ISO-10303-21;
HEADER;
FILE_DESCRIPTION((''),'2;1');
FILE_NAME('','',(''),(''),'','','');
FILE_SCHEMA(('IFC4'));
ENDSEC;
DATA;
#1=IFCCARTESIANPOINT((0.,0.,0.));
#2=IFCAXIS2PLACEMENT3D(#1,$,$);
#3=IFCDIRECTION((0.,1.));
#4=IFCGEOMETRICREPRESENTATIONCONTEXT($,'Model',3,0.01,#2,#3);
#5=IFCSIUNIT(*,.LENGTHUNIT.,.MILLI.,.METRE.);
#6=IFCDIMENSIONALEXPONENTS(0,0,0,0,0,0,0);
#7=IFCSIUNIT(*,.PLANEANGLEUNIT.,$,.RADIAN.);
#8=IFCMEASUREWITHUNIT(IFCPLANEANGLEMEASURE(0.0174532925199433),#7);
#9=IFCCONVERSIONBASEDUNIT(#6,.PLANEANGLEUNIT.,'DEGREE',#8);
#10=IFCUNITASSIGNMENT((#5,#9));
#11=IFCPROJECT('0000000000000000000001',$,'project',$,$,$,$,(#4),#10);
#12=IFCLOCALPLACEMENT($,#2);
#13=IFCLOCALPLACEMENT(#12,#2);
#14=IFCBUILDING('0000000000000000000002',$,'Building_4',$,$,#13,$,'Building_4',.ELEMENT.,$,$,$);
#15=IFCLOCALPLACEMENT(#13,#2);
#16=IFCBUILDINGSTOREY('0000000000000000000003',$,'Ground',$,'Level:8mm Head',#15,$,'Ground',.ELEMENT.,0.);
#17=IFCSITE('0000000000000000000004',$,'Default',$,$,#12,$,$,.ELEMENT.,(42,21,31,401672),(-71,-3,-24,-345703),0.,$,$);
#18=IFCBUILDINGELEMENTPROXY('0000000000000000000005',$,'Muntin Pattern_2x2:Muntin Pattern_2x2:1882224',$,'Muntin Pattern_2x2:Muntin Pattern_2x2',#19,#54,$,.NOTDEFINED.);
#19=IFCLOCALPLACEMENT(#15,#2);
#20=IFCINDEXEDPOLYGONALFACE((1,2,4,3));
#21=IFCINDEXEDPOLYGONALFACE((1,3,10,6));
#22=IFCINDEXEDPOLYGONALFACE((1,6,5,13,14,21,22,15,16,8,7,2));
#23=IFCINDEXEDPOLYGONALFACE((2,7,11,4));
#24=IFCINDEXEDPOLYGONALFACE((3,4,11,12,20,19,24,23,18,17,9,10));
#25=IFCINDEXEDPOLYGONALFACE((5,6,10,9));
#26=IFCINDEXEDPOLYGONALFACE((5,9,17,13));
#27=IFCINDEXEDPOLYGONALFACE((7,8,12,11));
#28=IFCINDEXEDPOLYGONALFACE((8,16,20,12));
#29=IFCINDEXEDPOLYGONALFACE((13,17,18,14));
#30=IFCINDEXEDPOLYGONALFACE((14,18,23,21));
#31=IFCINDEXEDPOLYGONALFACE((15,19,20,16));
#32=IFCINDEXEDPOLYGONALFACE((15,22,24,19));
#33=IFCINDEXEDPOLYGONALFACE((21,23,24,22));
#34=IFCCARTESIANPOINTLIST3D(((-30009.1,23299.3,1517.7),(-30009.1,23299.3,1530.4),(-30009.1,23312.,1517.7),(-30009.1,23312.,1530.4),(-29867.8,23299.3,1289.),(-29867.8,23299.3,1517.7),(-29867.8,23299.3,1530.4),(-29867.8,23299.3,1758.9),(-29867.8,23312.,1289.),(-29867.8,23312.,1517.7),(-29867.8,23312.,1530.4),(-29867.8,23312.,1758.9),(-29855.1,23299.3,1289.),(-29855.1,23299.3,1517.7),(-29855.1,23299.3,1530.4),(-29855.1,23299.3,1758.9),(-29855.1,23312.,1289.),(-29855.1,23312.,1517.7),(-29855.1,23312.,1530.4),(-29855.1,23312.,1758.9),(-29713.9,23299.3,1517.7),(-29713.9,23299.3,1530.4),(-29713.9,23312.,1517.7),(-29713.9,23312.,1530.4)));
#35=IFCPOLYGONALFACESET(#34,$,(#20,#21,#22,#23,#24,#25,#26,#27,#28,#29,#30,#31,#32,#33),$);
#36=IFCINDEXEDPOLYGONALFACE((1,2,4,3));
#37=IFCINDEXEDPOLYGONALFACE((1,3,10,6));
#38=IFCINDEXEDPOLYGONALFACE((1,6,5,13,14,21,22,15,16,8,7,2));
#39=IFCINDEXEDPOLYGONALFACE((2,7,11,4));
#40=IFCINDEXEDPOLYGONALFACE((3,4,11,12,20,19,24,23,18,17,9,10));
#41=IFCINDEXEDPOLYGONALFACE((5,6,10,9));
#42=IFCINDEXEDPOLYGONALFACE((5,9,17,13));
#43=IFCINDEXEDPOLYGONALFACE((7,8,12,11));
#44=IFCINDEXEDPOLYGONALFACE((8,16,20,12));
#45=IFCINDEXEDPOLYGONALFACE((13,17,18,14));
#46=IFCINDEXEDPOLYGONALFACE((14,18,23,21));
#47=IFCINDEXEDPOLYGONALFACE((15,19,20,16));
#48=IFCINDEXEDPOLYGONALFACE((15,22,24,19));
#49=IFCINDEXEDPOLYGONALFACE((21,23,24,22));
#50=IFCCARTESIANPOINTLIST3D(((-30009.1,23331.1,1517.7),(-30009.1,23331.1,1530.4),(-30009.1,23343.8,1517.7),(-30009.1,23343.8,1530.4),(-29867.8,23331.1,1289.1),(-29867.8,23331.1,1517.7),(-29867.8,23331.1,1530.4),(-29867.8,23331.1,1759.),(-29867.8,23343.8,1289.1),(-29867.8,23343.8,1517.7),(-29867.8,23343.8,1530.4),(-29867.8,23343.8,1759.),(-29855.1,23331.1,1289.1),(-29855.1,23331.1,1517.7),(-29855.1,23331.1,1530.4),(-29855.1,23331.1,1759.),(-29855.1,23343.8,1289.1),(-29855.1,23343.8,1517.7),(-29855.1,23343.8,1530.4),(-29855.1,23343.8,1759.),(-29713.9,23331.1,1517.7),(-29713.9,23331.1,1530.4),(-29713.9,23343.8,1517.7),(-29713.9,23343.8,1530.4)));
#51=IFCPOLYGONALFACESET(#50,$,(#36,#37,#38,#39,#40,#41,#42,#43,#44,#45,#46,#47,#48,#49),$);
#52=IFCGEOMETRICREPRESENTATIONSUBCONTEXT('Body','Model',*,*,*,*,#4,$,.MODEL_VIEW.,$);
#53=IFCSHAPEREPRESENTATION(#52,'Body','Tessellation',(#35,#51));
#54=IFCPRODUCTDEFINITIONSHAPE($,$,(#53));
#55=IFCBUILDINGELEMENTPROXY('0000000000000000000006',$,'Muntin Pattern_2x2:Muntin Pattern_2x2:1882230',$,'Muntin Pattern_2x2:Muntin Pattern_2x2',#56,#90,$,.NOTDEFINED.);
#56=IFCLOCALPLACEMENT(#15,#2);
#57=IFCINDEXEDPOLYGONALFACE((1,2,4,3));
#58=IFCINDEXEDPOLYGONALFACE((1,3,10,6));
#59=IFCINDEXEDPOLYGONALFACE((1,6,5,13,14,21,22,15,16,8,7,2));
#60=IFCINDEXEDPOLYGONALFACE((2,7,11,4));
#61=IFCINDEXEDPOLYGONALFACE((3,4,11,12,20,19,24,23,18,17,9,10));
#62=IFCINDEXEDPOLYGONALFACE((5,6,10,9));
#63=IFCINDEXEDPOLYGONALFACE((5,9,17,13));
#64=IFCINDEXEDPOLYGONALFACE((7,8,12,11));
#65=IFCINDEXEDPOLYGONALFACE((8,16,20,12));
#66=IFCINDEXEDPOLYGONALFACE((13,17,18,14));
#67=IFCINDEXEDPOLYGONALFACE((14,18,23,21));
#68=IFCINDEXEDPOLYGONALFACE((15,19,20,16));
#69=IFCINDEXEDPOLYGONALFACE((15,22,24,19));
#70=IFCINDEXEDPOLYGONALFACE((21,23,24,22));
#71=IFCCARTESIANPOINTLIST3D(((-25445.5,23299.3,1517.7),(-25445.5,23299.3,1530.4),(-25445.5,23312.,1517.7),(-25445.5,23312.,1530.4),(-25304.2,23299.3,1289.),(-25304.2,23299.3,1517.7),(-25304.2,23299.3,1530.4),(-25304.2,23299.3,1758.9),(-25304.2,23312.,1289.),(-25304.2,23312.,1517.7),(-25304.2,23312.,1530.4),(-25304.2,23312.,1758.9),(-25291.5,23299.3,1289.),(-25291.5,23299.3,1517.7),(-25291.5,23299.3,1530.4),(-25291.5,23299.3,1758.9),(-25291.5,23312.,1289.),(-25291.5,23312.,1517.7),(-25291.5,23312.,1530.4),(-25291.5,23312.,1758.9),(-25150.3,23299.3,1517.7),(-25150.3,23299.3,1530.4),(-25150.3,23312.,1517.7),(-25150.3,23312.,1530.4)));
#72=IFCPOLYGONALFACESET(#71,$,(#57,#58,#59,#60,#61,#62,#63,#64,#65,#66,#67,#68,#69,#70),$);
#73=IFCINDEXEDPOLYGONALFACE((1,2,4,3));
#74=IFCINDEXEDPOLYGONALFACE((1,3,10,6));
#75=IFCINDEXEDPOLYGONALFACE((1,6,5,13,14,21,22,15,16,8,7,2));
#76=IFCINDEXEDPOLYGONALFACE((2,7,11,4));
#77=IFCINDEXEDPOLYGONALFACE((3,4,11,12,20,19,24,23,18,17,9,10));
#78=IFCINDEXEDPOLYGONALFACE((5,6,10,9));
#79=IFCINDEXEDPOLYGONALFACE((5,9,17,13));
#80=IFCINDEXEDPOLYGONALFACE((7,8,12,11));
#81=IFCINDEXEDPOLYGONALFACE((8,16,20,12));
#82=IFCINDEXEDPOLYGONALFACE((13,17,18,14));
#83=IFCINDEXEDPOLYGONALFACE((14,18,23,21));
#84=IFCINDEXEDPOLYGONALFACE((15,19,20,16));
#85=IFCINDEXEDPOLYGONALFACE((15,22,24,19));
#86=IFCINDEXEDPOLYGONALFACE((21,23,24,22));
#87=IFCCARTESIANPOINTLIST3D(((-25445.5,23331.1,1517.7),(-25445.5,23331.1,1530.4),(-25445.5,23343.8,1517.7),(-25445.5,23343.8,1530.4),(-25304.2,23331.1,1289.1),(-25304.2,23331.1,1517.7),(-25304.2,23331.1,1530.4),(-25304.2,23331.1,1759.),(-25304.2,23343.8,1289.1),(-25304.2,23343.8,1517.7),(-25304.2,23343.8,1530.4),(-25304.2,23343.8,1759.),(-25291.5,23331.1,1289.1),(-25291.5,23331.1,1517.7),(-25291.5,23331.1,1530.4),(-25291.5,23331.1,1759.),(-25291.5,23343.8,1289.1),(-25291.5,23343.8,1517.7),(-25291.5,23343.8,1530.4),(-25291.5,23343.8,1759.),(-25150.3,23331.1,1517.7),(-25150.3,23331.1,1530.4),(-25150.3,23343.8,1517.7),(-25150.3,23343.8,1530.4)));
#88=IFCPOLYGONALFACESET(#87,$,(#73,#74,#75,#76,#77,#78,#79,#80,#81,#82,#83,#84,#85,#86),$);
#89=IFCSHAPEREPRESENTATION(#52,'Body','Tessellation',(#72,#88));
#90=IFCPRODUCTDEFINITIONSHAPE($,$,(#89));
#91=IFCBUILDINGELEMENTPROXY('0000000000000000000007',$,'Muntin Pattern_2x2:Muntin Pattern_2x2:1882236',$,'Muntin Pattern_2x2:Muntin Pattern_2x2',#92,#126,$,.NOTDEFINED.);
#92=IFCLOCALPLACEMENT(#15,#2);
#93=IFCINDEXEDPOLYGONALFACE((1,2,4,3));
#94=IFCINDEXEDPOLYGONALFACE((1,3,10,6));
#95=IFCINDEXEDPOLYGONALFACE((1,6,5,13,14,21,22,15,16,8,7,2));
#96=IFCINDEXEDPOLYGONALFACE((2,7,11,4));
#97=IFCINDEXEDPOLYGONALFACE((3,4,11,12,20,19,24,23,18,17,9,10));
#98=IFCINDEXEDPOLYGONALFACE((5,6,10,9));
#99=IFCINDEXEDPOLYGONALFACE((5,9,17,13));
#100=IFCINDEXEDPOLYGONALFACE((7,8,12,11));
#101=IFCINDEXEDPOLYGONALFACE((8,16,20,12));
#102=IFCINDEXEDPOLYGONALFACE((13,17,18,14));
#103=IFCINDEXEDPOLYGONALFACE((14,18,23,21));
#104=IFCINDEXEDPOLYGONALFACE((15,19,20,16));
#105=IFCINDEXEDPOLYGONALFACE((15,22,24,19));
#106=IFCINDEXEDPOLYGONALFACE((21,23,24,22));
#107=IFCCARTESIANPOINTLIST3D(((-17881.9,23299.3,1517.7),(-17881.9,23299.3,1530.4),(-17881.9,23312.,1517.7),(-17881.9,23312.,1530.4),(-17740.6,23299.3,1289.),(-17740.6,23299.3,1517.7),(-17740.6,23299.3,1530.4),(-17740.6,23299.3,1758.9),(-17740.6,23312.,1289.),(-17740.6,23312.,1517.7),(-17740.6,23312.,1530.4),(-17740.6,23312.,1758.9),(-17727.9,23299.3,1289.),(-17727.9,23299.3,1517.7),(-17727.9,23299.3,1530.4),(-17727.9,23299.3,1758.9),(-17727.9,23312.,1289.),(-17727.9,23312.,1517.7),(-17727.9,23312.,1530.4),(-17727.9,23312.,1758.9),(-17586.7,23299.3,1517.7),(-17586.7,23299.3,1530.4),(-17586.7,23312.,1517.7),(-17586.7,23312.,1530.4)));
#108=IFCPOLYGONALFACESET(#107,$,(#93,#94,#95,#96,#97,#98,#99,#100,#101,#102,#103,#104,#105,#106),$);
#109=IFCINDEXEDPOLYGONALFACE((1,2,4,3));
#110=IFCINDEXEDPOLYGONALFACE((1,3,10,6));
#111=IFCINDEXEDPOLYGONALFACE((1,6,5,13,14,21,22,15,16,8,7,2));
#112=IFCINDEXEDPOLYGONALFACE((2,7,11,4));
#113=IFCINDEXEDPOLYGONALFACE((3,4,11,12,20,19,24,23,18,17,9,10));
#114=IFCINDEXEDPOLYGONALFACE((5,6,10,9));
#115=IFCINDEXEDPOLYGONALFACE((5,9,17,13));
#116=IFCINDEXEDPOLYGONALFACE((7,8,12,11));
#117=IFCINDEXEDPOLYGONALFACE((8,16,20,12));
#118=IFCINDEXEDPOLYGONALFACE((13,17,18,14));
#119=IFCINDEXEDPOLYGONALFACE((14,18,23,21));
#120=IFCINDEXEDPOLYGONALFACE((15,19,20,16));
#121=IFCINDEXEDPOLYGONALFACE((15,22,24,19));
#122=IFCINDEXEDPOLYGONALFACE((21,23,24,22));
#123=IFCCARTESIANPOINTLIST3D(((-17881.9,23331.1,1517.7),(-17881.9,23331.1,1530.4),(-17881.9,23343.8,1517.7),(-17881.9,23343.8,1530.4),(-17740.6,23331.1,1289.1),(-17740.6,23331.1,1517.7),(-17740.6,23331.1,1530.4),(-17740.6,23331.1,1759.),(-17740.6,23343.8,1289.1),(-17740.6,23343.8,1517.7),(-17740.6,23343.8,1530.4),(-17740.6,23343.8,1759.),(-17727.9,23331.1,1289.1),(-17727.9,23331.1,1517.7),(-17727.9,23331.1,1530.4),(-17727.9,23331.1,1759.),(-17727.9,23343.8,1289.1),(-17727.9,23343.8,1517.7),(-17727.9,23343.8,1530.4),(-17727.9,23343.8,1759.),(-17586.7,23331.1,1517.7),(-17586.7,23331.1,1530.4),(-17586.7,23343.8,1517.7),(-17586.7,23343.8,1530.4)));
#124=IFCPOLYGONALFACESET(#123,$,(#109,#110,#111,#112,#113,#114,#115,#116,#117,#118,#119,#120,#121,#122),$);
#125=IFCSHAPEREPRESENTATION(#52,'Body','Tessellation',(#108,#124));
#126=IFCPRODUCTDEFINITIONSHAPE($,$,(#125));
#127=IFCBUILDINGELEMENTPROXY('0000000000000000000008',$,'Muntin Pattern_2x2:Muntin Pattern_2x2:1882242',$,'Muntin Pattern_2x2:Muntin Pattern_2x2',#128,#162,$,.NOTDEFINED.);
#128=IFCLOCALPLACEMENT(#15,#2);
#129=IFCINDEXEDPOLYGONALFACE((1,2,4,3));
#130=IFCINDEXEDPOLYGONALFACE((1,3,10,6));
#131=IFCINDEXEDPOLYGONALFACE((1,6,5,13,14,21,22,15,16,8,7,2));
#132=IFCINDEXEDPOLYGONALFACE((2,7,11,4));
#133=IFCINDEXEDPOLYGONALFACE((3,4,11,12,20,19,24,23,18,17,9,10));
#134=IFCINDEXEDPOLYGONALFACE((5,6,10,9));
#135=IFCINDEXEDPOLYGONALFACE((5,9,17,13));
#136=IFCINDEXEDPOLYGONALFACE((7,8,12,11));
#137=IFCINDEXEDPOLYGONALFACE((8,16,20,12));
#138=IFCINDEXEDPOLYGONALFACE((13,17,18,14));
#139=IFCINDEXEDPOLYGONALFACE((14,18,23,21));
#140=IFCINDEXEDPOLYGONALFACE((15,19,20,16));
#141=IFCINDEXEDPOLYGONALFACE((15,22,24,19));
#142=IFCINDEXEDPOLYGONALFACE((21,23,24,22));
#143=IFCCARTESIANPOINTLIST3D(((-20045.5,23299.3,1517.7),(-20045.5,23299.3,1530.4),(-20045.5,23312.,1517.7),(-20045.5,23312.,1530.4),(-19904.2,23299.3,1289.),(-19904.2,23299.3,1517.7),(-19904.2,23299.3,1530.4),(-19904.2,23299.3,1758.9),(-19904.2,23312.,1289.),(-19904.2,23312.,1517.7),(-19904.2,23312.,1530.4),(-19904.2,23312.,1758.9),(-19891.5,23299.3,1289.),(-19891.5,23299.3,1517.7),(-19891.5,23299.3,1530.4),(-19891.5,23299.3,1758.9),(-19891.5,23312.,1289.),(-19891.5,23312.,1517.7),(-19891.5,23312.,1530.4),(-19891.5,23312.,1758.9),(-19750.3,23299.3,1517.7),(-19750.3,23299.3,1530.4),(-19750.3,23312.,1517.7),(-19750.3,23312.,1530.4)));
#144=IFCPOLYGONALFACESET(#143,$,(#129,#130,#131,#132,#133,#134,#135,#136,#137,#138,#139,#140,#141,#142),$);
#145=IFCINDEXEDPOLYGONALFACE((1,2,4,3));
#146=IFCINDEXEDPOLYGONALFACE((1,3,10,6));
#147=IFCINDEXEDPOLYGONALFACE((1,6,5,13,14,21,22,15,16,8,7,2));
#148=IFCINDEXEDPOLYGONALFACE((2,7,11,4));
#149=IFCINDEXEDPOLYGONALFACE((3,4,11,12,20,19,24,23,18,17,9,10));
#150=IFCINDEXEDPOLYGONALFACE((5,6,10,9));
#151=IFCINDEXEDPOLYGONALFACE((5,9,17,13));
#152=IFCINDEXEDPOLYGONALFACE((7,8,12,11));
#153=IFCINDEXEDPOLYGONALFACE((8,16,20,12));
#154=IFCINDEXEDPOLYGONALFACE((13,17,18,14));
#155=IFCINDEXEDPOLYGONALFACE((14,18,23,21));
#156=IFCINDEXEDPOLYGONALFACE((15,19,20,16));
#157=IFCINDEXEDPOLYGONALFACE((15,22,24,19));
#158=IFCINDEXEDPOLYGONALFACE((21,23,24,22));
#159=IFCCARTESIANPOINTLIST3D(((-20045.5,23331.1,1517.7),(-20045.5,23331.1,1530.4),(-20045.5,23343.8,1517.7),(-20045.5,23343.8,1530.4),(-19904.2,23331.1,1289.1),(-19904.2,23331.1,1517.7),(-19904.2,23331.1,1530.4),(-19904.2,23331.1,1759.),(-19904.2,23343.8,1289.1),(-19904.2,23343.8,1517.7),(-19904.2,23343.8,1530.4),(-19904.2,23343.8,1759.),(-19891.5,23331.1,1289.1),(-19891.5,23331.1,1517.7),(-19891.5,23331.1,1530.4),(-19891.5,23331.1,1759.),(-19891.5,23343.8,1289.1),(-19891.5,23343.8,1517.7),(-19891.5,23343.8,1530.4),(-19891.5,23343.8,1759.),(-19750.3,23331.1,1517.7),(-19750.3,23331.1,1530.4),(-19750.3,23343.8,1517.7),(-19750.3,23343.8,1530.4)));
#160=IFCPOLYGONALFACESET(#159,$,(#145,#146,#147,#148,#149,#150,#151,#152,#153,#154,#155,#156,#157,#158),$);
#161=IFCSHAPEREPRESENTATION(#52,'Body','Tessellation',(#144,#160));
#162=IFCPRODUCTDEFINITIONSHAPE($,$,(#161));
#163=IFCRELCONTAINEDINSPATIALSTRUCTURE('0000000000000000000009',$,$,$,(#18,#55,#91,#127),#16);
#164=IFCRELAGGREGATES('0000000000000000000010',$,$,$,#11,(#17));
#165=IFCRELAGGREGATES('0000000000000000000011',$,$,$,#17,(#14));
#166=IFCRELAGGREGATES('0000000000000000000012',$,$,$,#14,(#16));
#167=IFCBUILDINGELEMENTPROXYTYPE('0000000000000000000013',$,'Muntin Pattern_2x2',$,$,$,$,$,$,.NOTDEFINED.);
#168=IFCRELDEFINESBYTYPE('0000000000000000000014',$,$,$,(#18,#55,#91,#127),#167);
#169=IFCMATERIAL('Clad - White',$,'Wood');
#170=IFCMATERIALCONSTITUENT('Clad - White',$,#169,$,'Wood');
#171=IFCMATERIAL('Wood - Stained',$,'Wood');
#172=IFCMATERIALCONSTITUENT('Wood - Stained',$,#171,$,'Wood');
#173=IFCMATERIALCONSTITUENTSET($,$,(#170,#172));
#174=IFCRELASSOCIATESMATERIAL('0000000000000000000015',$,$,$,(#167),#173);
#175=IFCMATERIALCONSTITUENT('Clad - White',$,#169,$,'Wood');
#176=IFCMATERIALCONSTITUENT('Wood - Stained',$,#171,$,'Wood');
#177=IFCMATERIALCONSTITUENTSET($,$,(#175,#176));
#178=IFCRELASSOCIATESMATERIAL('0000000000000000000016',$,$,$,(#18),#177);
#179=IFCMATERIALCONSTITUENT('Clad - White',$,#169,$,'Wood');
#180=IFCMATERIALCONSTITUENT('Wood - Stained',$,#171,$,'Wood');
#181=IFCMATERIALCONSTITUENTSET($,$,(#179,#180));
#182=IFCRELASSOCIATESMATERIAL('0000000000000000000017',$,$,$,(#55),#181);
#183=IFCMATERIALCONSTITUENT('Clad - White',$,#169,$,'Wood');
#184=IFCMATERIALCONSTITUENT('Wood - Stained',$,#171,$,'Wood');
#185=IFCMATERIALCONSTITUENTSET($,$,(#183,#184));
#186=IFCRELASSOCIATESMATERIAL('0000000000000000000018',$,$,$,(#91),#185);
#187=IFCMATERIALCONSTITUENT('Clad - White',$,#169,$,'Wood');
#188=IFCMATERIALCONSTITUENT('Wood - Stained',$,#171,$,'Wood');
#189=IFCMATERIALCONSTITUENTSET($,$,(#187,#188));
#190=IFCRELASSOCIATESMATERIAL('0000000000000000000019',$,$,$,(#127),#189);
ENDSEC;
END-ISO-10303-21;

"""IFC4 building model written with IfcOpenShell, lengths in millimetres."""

from ifc_helpers import new_model, entity, si_unit, converted_unit, direction, frame, origin, place, context, subcontext, project, spatial, indexed_curve, outline, extrude, source, transform, mapped, material, constituent, constituent_set, type_object, type_shapes, element, save


model = new_model("IFC4")

# Units and contexts
model_context = context("Model", 3, precision=0.01, world=origin(), true_north=direction((0.0, 1.0)))
body_context = subcontext(model_context, "Body", "Model", "MODEL_VIEW")
ifc_project = project(units=[si_unit("LENGTHUNIT", "METRE", prefix="MILLI"), converted_unit("PLANEANGLEUNIT", "DEGREE", entity("IfcPlaneAngleMeasure", 0.0174532925199433), si_unit("PLANEANGLEUNIT", "RADIAN"), dimensions=[0, 0, 0, 0, 0, 0, 0])], contexts=[model_context])

# Site, building, storey
site_placement = place(None, origin())
site = spatial("IfcSite", under=ifc_project, at=site_placement, Name="Default", CompositionType="ELEMENT", RefLatitude=(42, 21, 31, 401672), RefLongitude=(-71, -3, -24, -345703), RefElevation=0.0)
building_placement = place(site_placement, origin())
building = spatial("IfcBuilding", under=site, at=building_placement, Name="Building_4", LongName="Building_4", CompositionType="ELEMENT")
storey_placement = place(building_placement, origin())
storey = spatial("IfcBuildingStorey", under=building, at=storey_placement, Name="Ground", ObjectType="Level:8mm Head", LongName="Ground", CompositionType="ELEMENT", Elevation=0.0)

# Building element proxies
ifc_material_1 = material(Name="Clad - White", Category="Wood")
ifc_material_2 = material(Name="Wood - Stained", Category="Wood")
ifc_constituent_1 = constituent(ifc_material_1, Name="Clad - White", Category="Wood")
ifc_constituent_2 = constituent(ifc_material_2, Name="Wood - Stained", Category="Wood")
ifc_constituent_set_1 = constituent_set(constituents=[ifc_constituent_1, ifc_constituent_2])
ifc_constituent_3 = constituent(ifc_material_1, Name="Clad - White", Category="Wood")
ifc_constituent_4 = constituent(ifc_material_2, Name="Wood - Stained", Category="Wood")
ifc_constituent_set_2 = constituent_set(constituents=[ifc_constituent_3, ifc_constituent_4])
building_element_proxy_type_1 = type_object("IfcBuildingElementProxyType", Name="Muntin Pattern_2x2", PredefinedType="NOTDEFINED", material=ifc_constituent_set_2)
shared_shape_1 = source(origin(), body_context, "Body", "SweptSolid", [
    extrude(outline(indexed_curve([(6.4, -6.4), (234.9, -6.4), (234.9, 6.3), (6.4, 6.3), (6.4, 147.6), (-6.3, 147.6), (-6.3, 6.3), (-235.0, 6.3), (-235.0, -6.4), (-6.3, -6.4), (-6.3, -147.6), (6.4, -147.6), (6.4, -6.4)], self_intersect=False)), frame((0.0, -22.2, 234.9), z_axis=(0.0, 1.0, 0.0), x_axis=(0.0, 0.0, 1.0)), (0.0, 0.0, 1.0), 12.7),
    extrude(outline(indexed_curve([(6.4, -6.4), (235.0, -6.4), (235.0, 6.3), (6.4, 6.3), (6.4, 147.6), (-6.3, 147.6), (-6.3, 6.3), (-235.0, 6.3), (-235.0, -6.4), (-6.3, -6.4), (-6.3, -147.6), (6.4, -147.6), (6.4, -6.4)], self_intersect=False)), frame((0.0, 9.5, 235.0), z_axis=(0.0, 1.0, 0.0), x_axis=(0.0, 0.0, 1.0)), (0.0, 0.0, 1.0), 12.7),
])
type_shapes(building_element_proxy_type_1, [shared_shape_1])
proxy_1_placement = place(storey_placement, frame((-29861.5, 23321.5, 1289.1)))
element("IfcBuildingElementProxy", 1, at=proxy_1_placement, inside=storey, type_object=building_element_proxy_type_1, material=ifc_constituent_set_1, Name="Muntin Pattern_2x2:Muntin Pattern_2x2:1882224", ObjectType="Muntin Pattern_2x2:Muntin Pattern_2x2", PredefinedType="NOTDEFINED", context=body_context, shape_type="MappedRepresentation", body=[
    mapped(shared_shape_1, transform((0.0, 0.0, 0.0), scale=1.0)),
])
ifc_constituent_5 = constituent(ifc_material_1, Name="Clad - White", Category="Wood")
ifc_constituent_6 = constituent(ifc_material_2, Name="Wood - Stained", Category="Wood")
ifc_constituent_set_3 = constituent_set(constituents=[ifc_constituent_5, ifc_constituent_6])
proxy_2_placement = place(storey_placement, frame((-25297.9, 23321.5, 1289.1)))
element("IfcBuildingElementProxy", 2, at=proxy_2_placement, inside=storey, type_object=building_element_proxy_type_1, material=ifc_constituent_set_3, Name="Muntin Pattern_2x2:Muntin Pattern_2x2:1882230", ObjectType="Muntin Pattern_2x2:Muntin Pattern_2x2", PredefinedType="NOTDEFINED", context=body_context, shape_type="MappedRepresentation", body=[
    mapped(shared_shape_1, transform((0.0, 0.0, 0.0), scale=1.0)),
])
ifc_constituent_7 = constituent(ifc_material_1, Name="Clad - White", Category="Wood")
ifc_constituent_8 = constituent(ifc_material_2, Name="Wood - Stained", Category="Wood")
ifc_constituent_set_4 = constituent_set(constituents=[ifc_constituent_7, ifc_constituent_8])
proxy_3_placement = place(storey_placement, frame((-17734.3, 23321.5, 1289.1)))
element("IfcBuildingElementProxy", 3, at=proxy_3_placement, inside=storey, type_object=building_element_proxy_type_1, material=ifc_constituent_set_4, Name="Muntin Pattern_2x2:Muntin Pattern_2x2:1882236", ObjectType="Muntin Pattern_2x2:Muntin Pattern_2x2", PredefinedType="NOTDEFINED", context=body_context, shape_type="MappedRepresentation", body=[
    mapped(shared_shape_1, transform((0.0, 0.0, 0.0), scale=1.0)),
])
ifc_constituent_9 = constituent(ifc_material_1, Name="Clad - White", Category="Wood")
ifc_constituent_10 = constituent(ifc_material_2, Name="Wood - Stained", Category="Wood")
ifc_constituent_set_5 = constituent_set(constituents=[ifc_constituent_9, ifc_constituent_10])
proxy_4_placement = place(storey_placement, frame((-19897.9, 23321.5, 1289.1)))
element("IfcBuildingElementProxy", 4, at=proxy_4_placement, inside=storey, type_object=building_element_proxy_type_1, material=ifc_constituent_set_5, Name="Muntin Pattern_2x2:Muntin Pattern_2x2:1882242", ObjectType="Muntin Pattern_2x2:Muntin Pattern_2x2", PredefinedType="NOTDEFINED", context=body_context, shape_type="MappedRepresentation", body=[
    mapped(shared_shape_1, transform((0.0, 0.0, 0.0), scale=1.0)),
])

save(model, "model.ifc")
